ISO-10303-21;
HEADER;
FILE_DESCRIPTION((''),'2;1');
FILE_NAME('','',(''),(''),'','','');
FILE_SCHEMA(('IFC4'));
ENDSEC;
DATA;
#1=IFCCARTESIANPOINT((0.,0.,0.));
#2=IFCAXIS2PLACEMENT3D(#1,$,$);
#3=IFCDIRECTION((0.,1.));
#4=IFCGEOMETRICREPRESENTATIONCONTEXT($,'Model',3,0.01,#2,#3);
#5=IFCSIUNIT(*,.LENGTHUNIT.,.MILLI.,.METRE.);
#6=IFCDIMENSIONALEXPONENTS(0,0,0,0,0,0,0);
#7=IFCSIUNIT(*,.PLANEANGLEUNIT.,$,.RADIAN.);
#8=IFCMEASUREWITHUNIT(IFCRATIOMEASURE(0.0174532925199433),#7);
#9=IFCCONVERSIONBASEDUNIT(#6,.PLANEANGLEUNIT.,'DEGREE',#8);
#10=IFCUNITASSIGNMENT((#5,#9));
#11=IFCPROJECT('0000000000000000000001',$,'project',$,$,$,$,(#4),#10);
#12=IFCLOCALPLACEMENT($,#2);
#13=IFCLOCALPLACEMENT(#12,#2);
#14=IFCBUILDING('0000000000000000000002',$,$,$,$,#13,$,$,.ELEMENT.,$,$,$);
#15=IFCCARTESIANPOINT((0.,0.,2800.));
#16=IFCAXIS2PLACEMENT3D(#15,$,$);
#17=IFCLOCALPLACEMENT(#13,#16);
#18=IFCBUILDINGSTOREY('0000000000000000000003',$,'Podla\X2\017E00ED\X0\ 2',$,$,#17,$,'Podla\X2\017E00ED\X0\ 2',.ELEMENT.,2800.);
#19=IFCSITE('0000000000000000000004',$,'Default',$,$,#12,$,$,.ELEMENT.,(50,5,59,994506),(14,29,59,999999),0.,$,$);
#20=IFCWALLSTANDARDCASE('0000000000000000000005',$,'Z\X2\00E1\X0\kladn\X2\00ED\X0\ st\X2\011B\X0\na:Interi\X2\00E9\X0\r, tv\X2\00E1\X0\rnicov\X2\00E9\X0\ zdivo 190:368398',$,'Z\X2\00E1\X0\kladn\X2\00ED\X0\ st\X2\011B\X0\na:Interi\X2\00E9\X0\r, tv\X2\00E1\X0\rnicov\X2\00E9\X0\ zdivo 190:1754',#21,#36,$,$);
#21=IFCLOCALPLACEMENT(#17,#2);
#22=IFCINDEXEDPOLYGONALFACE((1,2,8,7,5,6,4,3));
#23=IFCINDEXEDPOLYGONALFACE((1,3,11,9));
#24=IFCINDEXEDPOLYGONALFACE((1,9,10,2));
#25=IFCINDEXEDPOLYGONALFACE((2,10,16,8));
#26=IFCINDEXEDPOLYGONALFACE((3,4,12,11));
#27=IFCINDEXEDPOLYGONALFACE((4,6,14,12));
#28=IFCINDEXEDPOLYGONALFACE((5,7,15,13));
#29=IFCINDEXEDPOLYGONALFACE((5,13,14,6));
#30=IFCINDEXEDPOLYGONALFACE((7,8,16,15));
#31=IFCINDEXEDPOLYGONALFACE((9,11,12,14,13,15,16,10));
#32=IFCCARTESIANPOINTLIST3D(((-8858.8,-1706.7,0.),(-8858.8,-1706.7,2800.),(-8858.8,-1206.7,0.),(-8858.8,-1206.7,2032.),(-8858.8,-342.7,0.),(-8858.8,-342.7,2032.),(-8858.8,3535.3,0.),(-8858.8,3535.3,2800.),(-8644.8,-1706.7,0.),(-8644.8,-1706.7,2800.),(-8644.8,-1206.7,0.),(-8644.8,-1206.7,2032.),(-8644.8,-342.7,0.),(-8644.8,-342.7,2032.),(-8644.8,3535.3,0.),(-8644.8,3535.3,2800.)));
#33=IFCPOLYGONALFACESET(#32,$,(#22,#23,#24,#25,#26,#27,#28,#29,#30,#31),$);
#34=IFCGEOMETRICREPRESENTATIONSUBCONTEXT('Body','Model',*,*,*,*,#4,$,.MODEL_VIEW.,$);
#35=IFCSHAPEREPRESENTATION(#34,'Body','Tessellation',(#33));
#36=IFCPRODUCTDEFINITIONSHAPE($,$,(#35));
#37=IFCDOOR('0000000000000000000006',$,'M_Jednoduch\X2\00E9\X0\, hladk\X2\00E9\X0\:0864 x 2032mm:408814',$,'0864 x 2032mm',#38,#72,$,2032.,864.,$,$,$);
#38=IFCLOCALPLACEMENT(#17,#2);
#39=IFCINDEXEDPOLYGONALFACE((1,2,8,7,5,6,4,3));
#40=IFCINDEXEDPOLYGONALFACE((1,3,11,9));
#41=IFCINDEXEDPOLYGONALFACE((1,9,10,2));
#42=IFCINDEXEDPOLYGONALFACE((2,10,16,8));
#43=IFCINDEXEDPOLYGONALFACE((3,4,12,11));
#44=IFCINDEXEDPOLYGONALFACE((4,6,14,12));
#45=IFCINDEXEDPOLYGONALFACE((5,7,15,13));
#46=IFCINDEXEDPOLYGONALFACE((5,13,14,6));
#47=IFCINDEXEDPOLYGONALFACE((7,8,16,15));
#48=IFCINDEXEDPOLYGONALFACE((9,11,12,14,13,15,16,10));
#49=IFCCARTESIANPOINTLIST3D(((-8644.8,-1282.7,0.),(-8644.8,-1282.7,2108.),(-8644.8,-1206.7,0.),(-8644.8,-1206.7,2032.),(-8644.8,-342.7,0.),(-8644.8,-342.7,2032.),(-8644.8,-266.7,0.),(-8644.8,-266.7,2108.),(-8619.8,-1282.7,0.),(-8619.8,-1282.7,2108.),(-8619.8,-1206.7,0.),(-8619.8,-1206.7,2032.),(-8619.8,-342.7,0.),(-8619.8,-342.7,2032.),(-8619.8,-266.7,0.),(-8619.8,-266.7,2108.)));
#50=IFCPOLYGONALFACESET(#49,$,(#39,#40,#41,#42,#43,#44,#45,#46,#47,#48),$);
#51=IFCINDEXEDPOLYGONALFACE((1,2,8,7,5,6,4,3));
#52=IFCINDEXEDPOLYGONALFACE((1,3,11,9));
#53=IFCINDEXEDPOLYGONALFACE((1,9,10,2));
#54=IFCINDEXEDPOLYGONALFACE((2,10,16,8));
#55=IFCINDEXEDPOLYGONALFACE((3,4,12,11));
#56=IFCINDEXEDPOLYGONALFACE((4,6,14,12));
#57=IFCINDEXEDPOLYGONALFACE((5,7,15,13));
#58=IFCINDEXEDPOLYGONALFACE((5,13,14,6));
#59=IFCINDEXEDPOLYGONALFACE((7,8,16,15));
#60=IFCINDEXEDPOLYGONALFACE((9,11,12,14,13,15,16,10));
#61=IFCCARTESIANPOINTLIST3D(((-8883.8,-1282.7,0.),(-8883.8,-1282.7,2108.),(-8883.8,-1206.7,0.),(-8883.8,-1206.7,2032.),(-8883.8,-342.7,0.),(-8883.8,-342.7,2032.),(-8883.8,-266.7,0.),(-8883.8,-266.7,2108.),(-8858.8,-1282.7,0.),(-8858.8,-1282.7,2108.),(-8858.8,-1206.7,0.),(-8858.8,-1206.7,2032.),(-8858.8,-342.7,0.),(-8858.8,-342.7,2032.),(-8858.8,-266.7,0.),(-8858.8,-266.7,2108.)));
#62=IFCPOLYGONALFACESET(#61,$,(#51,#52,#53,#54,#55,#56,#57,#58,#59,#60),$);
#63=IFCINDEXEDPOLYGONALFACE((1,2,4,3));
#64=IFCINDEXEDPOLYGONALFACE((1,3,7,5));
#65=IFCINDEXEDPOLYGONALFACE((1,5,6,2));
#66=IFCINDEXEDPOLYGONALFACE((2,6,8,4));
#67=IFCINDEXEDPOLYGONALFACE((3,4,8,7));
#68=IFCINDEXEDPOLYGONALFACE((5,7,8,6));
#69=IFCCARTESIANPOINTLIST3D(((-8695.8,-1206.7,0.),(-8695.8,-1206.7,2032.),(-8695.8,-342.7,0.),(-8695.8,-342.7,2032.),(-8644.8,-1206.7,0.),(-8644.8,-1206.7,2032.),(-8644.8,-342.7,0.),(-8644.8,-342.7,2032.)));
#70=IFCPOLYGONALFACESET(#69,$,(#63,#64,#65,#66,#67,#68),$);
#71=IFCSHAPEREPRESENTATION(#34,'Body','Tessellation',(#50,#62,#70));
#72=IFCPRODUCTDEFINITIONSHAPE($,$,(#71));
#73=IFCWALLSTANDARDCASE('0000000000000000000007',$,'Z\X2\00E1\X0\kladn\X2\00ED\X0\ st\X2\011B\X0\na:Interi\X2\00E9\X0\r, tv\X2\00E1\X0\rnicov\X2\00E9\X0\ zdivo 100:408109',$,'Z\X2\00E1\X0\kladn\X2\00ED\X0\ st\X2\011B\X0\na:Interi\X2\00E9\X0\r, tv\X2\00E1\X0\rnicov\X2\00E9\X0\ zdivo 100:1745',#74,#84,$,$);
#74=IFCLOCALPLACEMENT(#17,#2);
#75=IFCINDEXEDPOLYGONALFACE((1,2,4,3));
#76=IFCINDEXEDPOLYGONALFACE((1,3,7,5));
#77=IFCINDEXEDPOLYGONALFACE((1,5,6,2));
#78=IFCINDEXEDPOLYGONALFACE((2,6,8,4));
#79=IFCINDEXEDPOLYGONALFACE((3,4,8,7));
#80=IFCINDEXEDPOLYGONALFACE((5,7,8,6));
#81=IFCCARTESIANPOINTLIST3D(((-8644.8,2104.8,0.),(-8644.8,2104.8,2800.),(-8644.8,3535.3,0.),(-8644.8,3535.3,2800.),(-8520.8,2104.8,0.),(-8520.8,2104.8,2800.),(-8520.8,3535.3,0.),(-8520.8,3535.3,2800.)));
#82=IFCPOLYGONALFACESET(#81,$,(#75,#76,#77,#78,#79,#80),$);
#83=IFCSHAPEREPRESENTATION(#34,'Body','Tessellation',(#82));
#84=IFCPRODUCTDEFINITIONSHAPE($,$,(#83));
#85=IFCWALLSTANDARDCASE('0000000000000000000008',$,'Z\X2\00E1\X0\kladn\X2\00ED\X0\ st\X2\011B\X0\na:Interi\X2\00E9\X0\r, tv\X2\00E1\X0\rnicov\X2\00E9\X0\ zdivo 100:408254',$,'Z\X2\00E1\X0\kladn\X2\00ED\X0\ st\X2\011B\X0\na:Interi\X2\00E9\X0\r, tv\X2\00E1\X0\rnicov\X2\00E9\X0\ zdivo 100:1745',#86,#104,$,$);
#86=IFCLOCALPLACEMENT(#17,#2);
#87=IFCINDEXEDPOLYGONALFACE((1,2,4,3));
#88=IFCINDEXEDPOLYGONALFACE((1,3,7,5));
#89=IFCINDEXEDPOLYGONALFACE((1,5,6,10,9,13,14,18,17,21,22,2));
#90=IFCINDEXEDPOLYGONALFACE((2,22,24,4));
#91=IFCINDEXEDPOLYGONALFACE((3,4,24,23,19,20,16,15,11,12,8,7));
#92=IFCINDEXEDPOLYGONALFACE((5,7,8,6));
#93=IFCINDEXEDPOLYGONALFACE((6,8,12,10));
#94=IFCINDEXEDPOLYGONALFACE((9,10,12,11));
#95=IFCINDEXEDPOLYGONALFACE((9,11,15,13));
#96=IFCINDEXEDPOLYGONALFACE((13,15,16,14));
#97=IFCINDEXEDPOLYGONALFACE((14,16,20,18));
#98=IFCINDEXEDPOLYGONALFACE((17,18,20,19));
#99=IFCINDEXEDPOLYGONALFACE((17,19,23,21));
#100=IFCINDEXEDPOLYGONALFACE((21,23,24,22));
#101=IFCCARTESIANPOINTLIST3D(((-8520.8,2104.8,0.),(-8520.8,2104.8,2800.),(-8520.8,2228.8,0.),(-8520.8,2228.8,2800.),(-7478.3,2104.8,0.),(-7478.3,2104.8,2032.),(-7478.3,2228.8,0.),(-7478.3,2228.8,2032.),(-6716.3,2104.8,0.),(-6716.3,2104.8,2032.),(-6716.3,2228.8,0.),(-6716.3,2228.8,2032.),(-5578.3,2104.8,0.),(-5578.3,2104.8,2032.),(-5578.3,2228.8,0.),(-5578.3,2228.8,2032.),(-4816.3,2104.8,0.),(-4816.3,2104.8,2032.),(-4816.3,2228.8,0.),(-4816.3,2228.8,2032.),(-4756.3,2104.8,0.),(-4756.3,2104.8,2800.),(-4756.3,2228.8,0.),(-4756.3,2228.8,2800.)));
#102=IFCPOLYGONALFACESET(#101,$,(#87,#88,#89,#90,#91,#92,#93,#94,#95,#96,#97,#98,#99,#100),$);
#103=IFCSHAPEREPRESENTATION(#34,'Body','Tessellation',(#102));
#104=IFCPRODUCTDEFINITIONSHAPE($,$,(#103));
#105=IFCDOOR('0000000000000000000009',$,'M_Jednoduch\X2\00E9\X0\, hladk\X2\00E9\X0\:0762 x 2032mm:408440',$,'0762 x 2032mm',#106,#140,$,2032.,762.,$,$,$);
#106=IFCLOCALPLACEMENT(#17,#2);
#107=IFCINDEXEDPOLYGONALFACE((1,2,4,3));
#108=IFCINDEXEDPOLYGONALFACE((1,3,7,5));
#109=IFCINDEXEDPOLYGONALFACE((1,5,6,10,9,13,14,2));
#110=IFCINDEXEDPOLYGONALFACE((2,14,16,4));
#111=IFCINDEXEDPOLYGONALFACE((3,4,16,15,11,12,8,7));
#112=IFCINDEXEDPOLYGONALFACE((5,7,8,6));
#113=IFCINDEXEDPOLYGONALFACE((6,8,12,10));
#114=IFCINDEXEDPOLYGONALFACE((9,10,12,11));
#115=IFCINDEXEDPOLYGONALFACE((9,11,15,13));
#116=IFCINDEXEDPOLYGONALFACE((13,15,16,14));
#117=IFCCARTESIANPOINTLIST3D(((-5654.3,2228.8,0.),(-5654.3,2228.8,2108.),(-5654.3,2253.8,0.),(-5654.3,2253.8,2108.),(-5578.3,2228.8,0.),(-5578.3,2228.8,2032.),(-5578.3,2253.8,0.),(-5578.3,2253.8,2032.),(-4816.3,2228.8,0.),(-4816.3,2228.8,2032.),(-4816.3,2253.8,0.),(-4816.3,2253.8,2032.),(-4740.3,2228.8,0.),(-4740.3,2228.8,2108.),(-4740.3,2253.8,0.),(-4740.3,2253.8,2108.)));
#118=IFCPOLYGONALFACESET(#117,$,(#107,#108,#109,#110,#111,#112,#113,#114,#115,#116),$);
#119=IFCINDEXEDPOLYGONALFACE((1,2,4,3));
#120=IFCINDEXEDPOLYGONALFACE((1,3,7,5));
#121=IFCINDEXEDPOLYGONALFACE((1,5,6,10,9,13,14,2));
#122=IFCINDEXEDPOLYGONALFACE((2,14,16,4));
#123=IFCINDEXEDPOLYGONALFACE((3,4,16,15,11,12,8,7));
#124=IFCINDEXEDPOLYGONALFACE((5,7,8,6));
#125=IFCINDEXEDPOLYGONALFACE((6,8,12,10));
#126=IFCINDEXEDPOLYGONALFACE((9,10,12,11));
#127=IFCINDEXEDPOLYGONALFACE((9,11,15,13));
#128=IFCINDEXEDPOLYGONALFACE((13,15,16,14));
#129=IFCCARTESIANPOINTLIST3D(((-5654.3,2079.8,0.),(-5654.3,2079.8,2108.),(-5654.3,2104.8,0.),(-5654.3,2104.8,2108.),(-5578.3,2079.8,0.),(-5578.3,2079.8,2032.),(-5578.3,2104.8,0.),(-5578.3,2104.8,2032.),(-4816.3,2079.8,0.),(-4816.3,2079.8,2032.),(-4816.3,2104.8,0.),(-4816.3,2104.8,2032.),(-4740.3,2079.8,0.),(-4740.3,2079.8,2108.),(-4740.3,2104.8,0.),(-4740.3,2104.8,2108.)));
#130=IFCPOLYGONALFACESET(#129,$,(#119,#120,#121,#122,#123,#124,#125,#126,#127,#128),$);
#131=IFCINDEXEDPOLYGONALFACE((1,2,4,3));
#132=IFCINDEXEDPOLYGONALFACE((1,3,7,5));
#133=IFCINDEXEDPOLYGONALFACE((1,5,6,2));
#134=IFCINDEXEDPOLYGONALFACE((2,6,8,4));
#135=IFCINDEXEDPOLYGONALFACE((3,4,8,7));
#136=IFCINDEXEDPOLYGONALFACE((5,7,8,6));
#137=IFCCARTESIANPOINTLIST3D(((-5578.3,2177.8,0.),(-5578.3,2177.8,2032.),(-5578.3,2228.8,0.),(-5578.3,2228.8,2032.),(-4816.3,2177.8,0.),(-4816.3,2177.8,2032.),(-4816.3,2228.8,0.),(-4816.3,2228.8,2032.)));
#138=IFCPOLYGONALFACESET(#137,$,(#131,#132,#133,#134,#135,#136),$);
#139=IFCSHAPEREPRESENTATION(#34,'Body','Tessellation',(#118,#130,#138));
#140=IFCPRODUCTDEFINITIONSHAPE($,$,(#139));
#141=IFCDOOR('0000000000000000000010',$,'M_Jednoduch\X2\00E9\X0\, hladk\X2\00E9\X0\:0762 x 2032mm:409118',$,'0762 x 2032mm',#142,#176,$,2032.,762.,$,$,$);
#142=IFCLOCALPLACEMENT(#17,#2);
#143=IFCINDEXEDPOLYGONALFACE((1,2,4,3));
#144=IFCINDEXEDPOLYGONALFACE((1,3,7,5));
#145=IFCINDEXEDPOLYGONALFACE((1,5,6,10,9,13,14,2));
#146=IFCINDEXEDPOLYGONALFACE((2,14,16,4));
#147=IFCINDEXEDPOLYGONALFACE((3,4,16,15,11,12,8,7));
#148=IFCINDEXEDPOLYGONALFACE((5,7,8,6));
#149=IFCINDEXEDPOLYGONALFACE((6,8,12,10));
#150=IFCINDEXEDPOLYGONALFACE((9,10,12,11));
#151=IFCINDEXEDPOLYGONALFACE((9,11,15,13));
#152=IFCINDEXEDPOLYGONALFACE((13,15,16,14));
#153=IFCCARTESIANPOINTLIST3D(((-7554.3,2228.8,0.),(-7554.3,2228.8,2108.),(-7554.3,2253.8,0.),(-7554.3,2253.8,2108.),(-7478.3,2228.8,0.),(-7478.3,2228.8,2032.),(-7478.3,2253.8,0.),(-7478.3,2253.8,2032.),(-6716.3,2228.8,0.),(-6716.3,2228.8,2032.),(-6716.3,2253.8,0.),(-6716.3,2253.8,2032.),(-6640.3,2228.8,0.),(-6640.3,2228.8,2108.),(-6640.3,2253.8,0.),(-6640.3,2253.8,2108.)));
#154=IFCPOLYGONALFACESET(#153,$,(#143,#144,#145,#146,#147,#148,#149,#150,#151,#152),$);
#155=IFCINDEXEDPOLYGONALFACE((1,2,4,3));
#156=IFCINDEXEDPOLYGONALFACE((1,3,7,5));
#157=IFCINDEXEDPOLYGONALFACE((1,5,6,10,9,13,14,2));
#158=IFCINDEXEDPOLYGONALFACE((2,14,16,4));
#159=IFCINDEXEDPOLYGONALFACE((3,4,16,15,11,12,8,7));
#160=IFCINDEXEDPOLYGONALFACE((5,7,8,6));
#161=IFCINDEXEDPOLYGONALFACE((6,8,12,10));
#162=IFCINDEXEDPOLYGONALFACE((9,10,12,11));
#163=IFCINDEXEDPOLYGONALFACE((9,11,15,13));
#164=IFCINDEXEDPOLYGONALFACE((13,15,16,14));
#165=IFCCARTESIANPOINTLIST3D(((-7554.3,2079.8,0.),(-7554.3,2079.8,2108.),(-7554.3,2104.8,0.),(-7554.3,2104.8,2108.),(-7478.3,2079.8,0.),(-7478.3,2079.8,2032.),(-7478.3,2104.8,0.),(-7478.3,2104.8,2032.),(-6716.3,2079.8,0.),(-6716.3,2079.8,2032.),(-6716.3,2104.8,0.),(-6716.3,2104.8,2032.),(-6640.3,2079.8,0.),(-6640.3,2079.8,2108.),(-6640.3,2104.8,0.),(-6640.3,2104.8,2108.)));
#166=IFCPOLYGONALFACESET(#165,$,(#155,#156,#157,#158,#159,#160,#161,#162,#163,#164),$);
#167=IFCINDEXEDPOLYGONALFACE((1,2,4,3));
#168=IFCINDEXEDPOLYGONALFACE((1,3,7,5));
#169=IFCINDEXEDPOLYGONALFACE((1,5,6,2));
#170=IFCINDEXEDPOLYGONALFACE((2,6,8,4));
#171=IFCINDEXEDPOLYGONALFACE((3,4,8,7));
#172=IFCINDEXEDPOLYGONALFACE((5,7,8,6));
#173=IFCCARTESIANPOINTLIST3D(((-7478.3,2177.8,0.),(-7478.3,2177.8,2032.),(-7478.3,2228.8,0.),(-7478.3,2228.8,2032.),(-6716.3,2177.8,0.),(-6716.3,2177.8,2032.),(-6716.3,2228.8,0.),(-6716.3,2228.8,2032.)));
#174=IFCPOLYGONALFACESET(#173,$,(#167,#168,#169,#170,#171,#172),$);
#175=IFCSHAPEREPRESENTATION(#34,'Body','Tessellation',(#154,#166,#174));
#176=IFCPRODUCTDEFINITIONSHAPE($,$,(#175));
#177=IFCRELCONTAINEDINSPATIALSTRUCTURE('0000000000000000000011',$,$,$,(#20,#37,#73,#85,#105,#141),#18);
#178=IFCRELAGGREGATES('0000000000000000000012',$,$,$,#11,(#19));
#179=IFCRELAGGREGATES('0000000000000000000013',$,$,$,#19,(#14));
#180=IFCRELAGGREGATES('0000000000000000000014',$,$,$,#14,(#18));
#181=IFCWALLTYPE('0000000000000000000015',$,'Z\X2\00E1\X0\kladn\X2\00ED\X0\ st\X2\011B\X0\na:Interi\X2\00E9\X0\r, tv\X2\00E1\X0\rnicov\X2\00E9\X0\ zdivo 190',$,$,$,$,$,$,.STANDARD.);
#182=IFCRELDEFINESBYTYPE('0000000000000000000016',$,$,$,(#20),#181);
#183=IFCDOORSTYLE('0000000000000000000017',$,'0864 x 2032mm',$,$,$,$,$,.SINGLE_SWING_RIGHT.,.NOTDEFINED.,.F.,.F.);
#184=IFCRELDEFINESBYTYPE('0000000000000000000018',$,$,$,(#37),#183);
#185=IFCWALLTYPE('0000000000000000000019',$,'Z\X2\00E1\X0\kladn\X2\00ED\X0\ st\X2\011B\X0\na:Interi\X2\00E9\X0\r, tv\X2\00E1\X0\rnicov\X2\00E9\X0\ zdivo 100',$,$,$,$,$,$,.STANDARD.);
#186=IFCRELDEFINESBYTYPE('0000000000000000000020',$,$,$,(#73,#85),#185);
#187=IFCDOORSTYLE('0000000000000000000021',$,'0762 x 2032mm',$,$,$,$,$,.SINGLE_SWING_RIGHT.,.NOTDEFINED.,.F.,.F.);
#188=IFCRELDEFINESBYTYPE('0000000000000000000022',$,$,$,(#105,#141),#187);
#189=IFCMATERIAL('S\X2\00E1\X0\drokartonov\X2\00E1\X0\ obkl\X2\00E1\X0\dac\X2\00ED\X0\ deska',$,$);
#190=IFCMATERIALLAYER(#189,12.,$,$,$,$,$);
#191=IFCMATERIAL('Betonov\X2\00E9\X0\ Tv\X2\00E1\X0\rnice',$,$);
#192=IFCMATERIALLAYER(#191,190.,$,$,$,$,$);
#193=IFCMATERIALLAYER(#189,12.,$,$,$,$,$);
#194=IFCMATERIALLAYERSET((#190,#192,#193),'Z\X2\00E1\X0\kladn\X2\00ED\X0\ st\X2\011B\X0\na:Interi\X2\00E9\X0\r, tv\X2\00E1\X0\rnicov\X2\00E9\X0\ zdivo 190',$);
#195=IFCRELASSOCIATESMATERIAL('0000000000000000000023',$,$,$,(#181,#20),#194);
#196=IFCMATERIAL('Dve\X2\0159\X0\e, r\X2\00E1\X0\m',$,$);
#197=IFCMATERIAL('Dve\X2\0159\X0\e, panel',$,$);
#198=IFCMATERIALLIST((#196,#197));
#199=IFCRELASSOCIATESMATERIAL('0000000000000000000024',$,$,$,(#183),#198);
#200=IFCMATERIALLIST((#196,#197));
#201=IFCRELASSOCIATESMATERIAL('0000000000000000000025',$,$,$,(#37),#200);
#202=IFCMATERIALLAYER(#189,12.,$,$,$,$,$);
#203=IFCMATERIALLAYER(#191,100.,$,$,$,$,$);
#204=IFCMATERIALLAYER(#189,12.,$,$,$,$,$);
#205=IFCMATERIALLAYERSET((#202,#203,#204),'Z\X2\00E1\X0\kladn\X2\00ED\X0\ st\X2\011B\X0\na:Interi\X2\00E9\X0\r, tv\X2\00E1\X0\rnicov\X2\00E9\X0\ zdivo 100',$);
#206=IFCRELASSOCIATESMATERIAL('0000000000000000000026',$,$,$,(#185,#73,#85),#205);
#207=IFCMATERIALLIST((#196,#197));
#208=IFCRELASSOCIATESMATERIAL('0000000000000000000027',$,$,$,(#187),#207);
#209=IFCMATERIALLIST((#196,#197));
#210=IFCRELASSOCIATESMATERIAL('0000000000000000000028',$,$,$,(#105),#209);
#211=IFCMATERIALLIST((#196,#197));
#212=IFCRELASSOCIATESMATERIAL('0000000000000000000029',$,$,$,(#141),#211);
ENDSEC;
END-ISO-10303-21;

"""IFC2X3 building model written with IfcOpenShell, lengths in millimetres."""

from ifc_helpers import new_model, entity, si_unit, converted_unit, direction, frame, frame_2d, origin, origin_2d_with_axis, place, context, subcontext, project, spatial, polyline, rectangle, outline, extrude, source, transform, mapped, material, material_list, layer, layer_set, layer_usage, type_object, type_shapes, element, fill, save


model = new_model("IFC2X3")

# Units and contexts
model_context = context("Model", 3, precision=0.01, world=origin(), true_north=direction((0.0, 1.0)))
body_context = subcontext(model_context, "Body", "Model", "MODEL_VIEW")
ifc_project = project(units=[si_unit("LENGTHUNIT", "METRE", prefix="MILLI"), converted_unit("PLANEANGLEUNIT", "DEGREE", entity("IfcRatioMeasure", 0.0174532925199433), si_unit("PLANEANGLEUNIT", "RADIAN"), dimensions=[0, 0, 0, 0, 0, 0, 0])], contexts=[model_context])

# Site, building, storey
site_placement = place(None, origin())
site = spatial("IfcSite", under=ifc_project, at=site_placement, Name="Default", CompositionType="ELEMENT", RefLatitude=(50, 5, 59, 994506), RefLongitude=(14, 29, 59, 999999), RefElevation=0.0)
building_placement = place(site_placement, origin())
building = spatial("IfcBuilding", under=site, at=building_placement, CompositionType="ELEMENT")
storey_placement = place(building_placement, frame((0.0, 0.0, 2800.0)))
storey = spatial("IfcBuildingStorey", under=building, at=storey_placement, Name="Podlaží 2", LongName="Podlaží 2", CompositionType="ELEMENT", Elevation=2800.0)

# Shared definitions
ifc_material_1 = material(Name="Betonové Tvárnice")
ifc_material_2 = material(Name="Sádrokartonová obkládací deska")

# Wall, opening, door
ifc_layer_1 = layer(ifc_material_2, 12.0)
ifc_layer_2 = layer(ifc_material_1, 190.0)
ifc_layer_3 = layer(ifc_material_2, 12.0)
ifc_layer_set_1 = layer_set([ifc_layer_1, ifc_layer_2, ifc_layer_3], Name="Základní stěna:Interiér, tvárnicové zdivo 190")
ifc_layer_usage_1 = layer_usage(ifc_layer_set_1, "AXIS2", "NEGATIVE", 107.0)
wall_type_1 = type_object("IfcWallType", Name="Základní stěna:Interiér, tvárnicové zdivo 190", PredefinedType="STANDARD", material=ifc_layer_set_1)
wall_1_placement = place(storey_placement, frame((-8751.8, 3535.3, 0.0), z_axis=(0.0, 0.0, 1.0), x_axis=(0.0, -1.0, 0.0)))
wall_1 = element("IfcWallStandardCase", 1, at=wall_1_placement, inside=storey, type_object=wall_type_1, material=ifc_layer_usage_1, Name="Základní stěna:Interiér, tvárnicové zdivo 190:368398", ObjectType="Základní stěna:Interiér, tvárnicové zdivo 190:1754", context=body_context, shape_type="SweptSolid", body=[
    extrude(rectangle(XDim=5242.0, YDim=214.0, at=frame_2d((2621.0, 0.0), x_axis=(-1.0, 0.0))), origin(), (0.0, 0.0, 1.0), 2800.0),
])
opening_1_placement = place(wall_1_placement, frame((3878.0, -107.0, 0.0)))
opening_1 = element("IfcOpeningElement", 2, at=opening_1_placement, cuts=wall_1, ObjectType="Opening", context=body_context, shape_type="SweptSolid", body=[
    extrude(rectangle(XDim=864.0, YDim=2032.0, at=frame_2d((1016.0, 432.0), x_axis=(0.0, 1.0))), frame((0.0, 0.0, 0.0), z_axis=(0.0, 1.0, 0.0), x_axis=(0.0, 0.0, 1.0)), (0.0, 0.0, 1.0), 214.0),
])
ifc_material_3 = material(Name="Dveře, rám")
ifc_material_4 = material(Name="Dveře, panel")
ifc_material_list_1 = material_list([ifc_material_3, ifc_material_4])
ifc_material_list_2 = material_list([ifc_material_3, ifc_material_4])
door_style_1 = type_object("IfcDoorStyle", Name="0864 x 2032mm", ConstructionType="NOTDEFINED", OperationType="SINGLE_SWING_RIGHT", ParameterTakesPrecedence=False, Sizeable=False, material=ifc_material_list_2)
shared_shape_1 = source(origin(), body_context, "Body", "SweptSolid", [
    extrude(outline(polyline([(-508.0, -1073.0), (508.0, -1073.0), (508.0, 1035.0), (432.0, 1035.0), (432.0, -997.0), (-432.0, -997.0), (-432.0, 1035.0), (-508.0, 1035.0), (-508.0, -1073.0)])), frame((432.0, 214.0, 1035.0), z_axis=(0.0, 1.0, 0.0), x_axis=(1.0, 0.0, 0.0)), (0.0, 0.0, 1.0), 25.0),
    extrude(outline(polyline([(-1073.0, -508.0), (1035.0, -508.0), (1035.0, -432.0), (-997.0, -432.0), (-997.0, 432.0), (1035.0, 432.0), (1035.0, 508.0), (-1073.0, 508.0), (-1073.0, -508.0)])), frame((432.0, -25.0, 1035.0), z_axis=(0.0, 1.0, 0.0), x_axis=(0.0, 0.0, -1.0)), (0.0, 0.0, 1.0), 25.0),
    extrude(rectangle(XDim=51.0, YDim=864.0, at=frame_2d((0.0, 0.0), x_axis=(1.0, 0.0))), frame((432.0, 188.5, 0.0), z_axis=(0.0, 0.0, 1.0), x_axis=(0.0, 1.0, 0.0)), (0.0, 0.0, 1.0), 2032.0),
])
type_shapes(door_style_1, [shared_shape_1])
door_1_placement = place(opening_1_placement, origin())
door_1 = element("IfcDoor", 3, at=door_1_placement, inside=storey, type_object=door_style_1, material=ifc_material_list_1, Name="M_Jednoduché, hladké:0864 x 2032mm:408814", ObjectType="0864 x 2032mm", OverallHeight=2032.0, OverallWidth=864.0, context=body_context, shape_type="MappedRepresentation", body=[
    mapped(shared_shape_1, transform((0.0, 0.0, 0.0), scale=1.0)),
])
fill(opening_1, door_1)

# Wall
ifc_layer_4 = layer(ifc_material_2, 12.0)
ifc_layer_5 = layer(ifc_material_1, 100.0)
ifc_layer_6 = layer(ifc_material_2, 12.0)
ifc_layer_set_2 = layer_set([ifc_layer_4, ifc_layer_5, ifc_layer_6], Name="Základní stěna:Interiér, tvárnicové zdivo 100")
ifc_layer_usage_2 = layer_usage(ifc_layer_set_2, "AXIS2", "POSITIVE", -62.0)
wall_type_2 = type_object("IfcWallType", Name="Základní stěna:Interiér, tvárnicové zdivo 100", PredefinedType="STANDARD", material=ifc_layer_set_2)
wall_2_placement = place(storey_placement, frame((-8582.8, 3535.3, 0.0), z_axis=(0.0, 0.0, 1.0), x_axis=(0.0, -1.0, 0.0)))
element("IfcWallStandardCase", 4, at=wall_2_placement, inside=storey, type_object=wall_type_2, material=ifc_layer_usage_2, Name="Základní stěna:Interiér, tvárnicové zdivo 100:408109", ObjectType="Základní stěna:Interiér, tvárnicové zdivo 100:1745", context=body_context, shape_type="SweptSolid", body=[
    extrude(rectangle(XDim=1430.5, YDim=124.0, at=frame_2d((715.2, 0.0), x_axis=(-1.0, 0.0))), origin(), (0.0, 0.0, 1.0), 2800.0),
])

# Wall, openings, doors
ifc_layer_usage_3 = layer_usage(ifc_layer_set_2, "AXIS2", "POSITIVE", -62.0)
wall_3_placement = place(storey_placement, frame((-8520.8, 2166.8, 0.0)))
wall_3 = element("IfcWallStandardCase", 5, at=wall_3_placement, inside=storey, type_object=wall_type_2, material=ifc_layer_usage_3, Name="Základní stěna:Interiér, tvárnicové zdivo 100:408254", ObjectType="Základní stěna:Interiér, tvárnicové zdivo 100:1745", context=body_context, shape_type="SweptSolid", body=[
    extrude(rectangle(XDim=3764.5, YDim=124.0, at=frame_2d((1882.2, 0.0), x_axis=(-1.0, 0.0))), origin(), (0.0, 0.0, 1.0), 2800.0),
])
opening_2_placement = place(wall_3_placement, frame((2942.5, -62.0, 0.0)))
opening_2 = element("IfcOpeningElement", 6, at=opening_2_placement, cuts=wall_3, ObjectType="Opening", context=body_context, shape_type="SweptSolid", body=[
    extrude(rectangle(XDim=762.0, YDim=2032.0, at=frame_2d((1016.0, 381.0), x_axis=(0.0, 1.0))), frame((0.0, 0.0, 0.0), z_axis=(0.0, 1.0, 0.0), x_axis=(0.0, 0.0, 1.0)), (0.0, 0.0, 1.0), 124.0),
])
opening_3_placement = place(wall_3_placement, frame((1042.5, -62.0, 0.0)))
opening_3 = element("IfcOpeningElement", 7, at=opening_3_placement, cuts=wall_3, ObjectType="Opening", context=body_context, shape_type="SweptSolid", body=[
    extrude(rectangle(XDim=762.0, YDim=2032.0, at=frame_2d((1016.0, 381.0), x_axis=(0.0, 1.0))), frame((0.0, 0.0, 0.0), z_axis=(0.0, 1.0, 0.0), x_axis=(0.0, 0.0, 1.0)), (0.0, 0.0, 1.0), 124.0),
])
ifc_material_list_3 = material_list([ifc_material_3, ifc_material_4])
ifc_material_list_4 = material_list([ifc_material_3, ifc_material_4])
door_style_2 = type_object("IfcDoorStyle", Name="0762 x 2032mm", ConstructionType="NOTDEFINED", OperationType="SINGLE_SWING_RIGHT", ParameterTakesPrecedence=False, Sizeable=False, material=ifc_material_list_4)
shared_shape_2 = source(origin(), body_context, "Body", "SweptSolid", [
    extrude(outline(polyline([(-457.0, -1073.0), (457.0, -1073.0), (457.0, 1035.0), (381.0, 1035.0), (381.0, -997.0), (-381.0, -997.0), (-381.0, 1035.0), (-457.0, 1035.0), (-457.0, -1073.0)])), frame((381.0, 124.0, 1035.0), z_axis=(0.0, 1.0, 0.0), x_axis=(1.0, 0.0, 0.0)), (0.0, 0.0, 1.0), 25.0),
    extrude(outline(polyline([(-1073.0, -457.0), (1035.0, -457.0), (1035.0, -381.0), (-997.0, -381.0), (-997.0, 381.0), (1035.0, 381.0), (1035.0, 457.0), (-1073.0, 457.0), (-1073.0, -457.0)])), frame((381.0, -25.0, 1035.0), z_axis=(0.0, 1.0, 0.0), x_axis=(0.0, 0.0, -1.0)), (0.0, 0.0, 1.0), 25.0),
    extrude(rectangle(XDim=51.0, YDim=762.0, at=origin_2d_with_axis()), frame((381.0, 98.5, 0.0), z_axis=(0.0, 0.0, 1.0), x_axis=(0.0, 1.0, 0.0)), (0.0, 0.0, 1.0), 2032.0),
])
type_shapes(door_style_2, [shared_shape_2])
door_2_placement = place(opening_2_placement, origin())
door_2 = element("IfcDoor", 8, at=door_2_placement, inside=storey, type_object=door_style_2, material=ifc_material_list_3, Name="M_Jednoduché, hladké:0762 x 2032mm:408440", ObjectType="0762 x 2032mm", OverallHeight=2032.0, OverallWidth=762.0, context=body_context, shape_type="MappedRepresentation", body=[
    mapped(shared_shape_2, transform((0.0, 0.0, 0.0), scale=1.0)),
])
fill(opening_2, door_2)
ifc_material_list_5 = material_list([ifc_material_3, ifc_material_4])
door_3_placement = place(opening_3_placement, origin())
door_3 = element("IfcDoor", 9, at=door_3_placement, inside=storey, type_object=door_style_2, material=ifc_material_list_5, Name="M_Jednoduché, hladké:0762 x 2032mm:409118", ObjectType="0762 x 2032mm", OverallHeight=2032.0, OverallWidth=762.0, context=body_context, shape_type="MappedRepresentation", body=[
    mapped(shared_shape_2, transform((0.0, 0.0, 0.0), scale=1.0)),
])
fill(opening_3, door_3)

save(model, "model.ifc")
